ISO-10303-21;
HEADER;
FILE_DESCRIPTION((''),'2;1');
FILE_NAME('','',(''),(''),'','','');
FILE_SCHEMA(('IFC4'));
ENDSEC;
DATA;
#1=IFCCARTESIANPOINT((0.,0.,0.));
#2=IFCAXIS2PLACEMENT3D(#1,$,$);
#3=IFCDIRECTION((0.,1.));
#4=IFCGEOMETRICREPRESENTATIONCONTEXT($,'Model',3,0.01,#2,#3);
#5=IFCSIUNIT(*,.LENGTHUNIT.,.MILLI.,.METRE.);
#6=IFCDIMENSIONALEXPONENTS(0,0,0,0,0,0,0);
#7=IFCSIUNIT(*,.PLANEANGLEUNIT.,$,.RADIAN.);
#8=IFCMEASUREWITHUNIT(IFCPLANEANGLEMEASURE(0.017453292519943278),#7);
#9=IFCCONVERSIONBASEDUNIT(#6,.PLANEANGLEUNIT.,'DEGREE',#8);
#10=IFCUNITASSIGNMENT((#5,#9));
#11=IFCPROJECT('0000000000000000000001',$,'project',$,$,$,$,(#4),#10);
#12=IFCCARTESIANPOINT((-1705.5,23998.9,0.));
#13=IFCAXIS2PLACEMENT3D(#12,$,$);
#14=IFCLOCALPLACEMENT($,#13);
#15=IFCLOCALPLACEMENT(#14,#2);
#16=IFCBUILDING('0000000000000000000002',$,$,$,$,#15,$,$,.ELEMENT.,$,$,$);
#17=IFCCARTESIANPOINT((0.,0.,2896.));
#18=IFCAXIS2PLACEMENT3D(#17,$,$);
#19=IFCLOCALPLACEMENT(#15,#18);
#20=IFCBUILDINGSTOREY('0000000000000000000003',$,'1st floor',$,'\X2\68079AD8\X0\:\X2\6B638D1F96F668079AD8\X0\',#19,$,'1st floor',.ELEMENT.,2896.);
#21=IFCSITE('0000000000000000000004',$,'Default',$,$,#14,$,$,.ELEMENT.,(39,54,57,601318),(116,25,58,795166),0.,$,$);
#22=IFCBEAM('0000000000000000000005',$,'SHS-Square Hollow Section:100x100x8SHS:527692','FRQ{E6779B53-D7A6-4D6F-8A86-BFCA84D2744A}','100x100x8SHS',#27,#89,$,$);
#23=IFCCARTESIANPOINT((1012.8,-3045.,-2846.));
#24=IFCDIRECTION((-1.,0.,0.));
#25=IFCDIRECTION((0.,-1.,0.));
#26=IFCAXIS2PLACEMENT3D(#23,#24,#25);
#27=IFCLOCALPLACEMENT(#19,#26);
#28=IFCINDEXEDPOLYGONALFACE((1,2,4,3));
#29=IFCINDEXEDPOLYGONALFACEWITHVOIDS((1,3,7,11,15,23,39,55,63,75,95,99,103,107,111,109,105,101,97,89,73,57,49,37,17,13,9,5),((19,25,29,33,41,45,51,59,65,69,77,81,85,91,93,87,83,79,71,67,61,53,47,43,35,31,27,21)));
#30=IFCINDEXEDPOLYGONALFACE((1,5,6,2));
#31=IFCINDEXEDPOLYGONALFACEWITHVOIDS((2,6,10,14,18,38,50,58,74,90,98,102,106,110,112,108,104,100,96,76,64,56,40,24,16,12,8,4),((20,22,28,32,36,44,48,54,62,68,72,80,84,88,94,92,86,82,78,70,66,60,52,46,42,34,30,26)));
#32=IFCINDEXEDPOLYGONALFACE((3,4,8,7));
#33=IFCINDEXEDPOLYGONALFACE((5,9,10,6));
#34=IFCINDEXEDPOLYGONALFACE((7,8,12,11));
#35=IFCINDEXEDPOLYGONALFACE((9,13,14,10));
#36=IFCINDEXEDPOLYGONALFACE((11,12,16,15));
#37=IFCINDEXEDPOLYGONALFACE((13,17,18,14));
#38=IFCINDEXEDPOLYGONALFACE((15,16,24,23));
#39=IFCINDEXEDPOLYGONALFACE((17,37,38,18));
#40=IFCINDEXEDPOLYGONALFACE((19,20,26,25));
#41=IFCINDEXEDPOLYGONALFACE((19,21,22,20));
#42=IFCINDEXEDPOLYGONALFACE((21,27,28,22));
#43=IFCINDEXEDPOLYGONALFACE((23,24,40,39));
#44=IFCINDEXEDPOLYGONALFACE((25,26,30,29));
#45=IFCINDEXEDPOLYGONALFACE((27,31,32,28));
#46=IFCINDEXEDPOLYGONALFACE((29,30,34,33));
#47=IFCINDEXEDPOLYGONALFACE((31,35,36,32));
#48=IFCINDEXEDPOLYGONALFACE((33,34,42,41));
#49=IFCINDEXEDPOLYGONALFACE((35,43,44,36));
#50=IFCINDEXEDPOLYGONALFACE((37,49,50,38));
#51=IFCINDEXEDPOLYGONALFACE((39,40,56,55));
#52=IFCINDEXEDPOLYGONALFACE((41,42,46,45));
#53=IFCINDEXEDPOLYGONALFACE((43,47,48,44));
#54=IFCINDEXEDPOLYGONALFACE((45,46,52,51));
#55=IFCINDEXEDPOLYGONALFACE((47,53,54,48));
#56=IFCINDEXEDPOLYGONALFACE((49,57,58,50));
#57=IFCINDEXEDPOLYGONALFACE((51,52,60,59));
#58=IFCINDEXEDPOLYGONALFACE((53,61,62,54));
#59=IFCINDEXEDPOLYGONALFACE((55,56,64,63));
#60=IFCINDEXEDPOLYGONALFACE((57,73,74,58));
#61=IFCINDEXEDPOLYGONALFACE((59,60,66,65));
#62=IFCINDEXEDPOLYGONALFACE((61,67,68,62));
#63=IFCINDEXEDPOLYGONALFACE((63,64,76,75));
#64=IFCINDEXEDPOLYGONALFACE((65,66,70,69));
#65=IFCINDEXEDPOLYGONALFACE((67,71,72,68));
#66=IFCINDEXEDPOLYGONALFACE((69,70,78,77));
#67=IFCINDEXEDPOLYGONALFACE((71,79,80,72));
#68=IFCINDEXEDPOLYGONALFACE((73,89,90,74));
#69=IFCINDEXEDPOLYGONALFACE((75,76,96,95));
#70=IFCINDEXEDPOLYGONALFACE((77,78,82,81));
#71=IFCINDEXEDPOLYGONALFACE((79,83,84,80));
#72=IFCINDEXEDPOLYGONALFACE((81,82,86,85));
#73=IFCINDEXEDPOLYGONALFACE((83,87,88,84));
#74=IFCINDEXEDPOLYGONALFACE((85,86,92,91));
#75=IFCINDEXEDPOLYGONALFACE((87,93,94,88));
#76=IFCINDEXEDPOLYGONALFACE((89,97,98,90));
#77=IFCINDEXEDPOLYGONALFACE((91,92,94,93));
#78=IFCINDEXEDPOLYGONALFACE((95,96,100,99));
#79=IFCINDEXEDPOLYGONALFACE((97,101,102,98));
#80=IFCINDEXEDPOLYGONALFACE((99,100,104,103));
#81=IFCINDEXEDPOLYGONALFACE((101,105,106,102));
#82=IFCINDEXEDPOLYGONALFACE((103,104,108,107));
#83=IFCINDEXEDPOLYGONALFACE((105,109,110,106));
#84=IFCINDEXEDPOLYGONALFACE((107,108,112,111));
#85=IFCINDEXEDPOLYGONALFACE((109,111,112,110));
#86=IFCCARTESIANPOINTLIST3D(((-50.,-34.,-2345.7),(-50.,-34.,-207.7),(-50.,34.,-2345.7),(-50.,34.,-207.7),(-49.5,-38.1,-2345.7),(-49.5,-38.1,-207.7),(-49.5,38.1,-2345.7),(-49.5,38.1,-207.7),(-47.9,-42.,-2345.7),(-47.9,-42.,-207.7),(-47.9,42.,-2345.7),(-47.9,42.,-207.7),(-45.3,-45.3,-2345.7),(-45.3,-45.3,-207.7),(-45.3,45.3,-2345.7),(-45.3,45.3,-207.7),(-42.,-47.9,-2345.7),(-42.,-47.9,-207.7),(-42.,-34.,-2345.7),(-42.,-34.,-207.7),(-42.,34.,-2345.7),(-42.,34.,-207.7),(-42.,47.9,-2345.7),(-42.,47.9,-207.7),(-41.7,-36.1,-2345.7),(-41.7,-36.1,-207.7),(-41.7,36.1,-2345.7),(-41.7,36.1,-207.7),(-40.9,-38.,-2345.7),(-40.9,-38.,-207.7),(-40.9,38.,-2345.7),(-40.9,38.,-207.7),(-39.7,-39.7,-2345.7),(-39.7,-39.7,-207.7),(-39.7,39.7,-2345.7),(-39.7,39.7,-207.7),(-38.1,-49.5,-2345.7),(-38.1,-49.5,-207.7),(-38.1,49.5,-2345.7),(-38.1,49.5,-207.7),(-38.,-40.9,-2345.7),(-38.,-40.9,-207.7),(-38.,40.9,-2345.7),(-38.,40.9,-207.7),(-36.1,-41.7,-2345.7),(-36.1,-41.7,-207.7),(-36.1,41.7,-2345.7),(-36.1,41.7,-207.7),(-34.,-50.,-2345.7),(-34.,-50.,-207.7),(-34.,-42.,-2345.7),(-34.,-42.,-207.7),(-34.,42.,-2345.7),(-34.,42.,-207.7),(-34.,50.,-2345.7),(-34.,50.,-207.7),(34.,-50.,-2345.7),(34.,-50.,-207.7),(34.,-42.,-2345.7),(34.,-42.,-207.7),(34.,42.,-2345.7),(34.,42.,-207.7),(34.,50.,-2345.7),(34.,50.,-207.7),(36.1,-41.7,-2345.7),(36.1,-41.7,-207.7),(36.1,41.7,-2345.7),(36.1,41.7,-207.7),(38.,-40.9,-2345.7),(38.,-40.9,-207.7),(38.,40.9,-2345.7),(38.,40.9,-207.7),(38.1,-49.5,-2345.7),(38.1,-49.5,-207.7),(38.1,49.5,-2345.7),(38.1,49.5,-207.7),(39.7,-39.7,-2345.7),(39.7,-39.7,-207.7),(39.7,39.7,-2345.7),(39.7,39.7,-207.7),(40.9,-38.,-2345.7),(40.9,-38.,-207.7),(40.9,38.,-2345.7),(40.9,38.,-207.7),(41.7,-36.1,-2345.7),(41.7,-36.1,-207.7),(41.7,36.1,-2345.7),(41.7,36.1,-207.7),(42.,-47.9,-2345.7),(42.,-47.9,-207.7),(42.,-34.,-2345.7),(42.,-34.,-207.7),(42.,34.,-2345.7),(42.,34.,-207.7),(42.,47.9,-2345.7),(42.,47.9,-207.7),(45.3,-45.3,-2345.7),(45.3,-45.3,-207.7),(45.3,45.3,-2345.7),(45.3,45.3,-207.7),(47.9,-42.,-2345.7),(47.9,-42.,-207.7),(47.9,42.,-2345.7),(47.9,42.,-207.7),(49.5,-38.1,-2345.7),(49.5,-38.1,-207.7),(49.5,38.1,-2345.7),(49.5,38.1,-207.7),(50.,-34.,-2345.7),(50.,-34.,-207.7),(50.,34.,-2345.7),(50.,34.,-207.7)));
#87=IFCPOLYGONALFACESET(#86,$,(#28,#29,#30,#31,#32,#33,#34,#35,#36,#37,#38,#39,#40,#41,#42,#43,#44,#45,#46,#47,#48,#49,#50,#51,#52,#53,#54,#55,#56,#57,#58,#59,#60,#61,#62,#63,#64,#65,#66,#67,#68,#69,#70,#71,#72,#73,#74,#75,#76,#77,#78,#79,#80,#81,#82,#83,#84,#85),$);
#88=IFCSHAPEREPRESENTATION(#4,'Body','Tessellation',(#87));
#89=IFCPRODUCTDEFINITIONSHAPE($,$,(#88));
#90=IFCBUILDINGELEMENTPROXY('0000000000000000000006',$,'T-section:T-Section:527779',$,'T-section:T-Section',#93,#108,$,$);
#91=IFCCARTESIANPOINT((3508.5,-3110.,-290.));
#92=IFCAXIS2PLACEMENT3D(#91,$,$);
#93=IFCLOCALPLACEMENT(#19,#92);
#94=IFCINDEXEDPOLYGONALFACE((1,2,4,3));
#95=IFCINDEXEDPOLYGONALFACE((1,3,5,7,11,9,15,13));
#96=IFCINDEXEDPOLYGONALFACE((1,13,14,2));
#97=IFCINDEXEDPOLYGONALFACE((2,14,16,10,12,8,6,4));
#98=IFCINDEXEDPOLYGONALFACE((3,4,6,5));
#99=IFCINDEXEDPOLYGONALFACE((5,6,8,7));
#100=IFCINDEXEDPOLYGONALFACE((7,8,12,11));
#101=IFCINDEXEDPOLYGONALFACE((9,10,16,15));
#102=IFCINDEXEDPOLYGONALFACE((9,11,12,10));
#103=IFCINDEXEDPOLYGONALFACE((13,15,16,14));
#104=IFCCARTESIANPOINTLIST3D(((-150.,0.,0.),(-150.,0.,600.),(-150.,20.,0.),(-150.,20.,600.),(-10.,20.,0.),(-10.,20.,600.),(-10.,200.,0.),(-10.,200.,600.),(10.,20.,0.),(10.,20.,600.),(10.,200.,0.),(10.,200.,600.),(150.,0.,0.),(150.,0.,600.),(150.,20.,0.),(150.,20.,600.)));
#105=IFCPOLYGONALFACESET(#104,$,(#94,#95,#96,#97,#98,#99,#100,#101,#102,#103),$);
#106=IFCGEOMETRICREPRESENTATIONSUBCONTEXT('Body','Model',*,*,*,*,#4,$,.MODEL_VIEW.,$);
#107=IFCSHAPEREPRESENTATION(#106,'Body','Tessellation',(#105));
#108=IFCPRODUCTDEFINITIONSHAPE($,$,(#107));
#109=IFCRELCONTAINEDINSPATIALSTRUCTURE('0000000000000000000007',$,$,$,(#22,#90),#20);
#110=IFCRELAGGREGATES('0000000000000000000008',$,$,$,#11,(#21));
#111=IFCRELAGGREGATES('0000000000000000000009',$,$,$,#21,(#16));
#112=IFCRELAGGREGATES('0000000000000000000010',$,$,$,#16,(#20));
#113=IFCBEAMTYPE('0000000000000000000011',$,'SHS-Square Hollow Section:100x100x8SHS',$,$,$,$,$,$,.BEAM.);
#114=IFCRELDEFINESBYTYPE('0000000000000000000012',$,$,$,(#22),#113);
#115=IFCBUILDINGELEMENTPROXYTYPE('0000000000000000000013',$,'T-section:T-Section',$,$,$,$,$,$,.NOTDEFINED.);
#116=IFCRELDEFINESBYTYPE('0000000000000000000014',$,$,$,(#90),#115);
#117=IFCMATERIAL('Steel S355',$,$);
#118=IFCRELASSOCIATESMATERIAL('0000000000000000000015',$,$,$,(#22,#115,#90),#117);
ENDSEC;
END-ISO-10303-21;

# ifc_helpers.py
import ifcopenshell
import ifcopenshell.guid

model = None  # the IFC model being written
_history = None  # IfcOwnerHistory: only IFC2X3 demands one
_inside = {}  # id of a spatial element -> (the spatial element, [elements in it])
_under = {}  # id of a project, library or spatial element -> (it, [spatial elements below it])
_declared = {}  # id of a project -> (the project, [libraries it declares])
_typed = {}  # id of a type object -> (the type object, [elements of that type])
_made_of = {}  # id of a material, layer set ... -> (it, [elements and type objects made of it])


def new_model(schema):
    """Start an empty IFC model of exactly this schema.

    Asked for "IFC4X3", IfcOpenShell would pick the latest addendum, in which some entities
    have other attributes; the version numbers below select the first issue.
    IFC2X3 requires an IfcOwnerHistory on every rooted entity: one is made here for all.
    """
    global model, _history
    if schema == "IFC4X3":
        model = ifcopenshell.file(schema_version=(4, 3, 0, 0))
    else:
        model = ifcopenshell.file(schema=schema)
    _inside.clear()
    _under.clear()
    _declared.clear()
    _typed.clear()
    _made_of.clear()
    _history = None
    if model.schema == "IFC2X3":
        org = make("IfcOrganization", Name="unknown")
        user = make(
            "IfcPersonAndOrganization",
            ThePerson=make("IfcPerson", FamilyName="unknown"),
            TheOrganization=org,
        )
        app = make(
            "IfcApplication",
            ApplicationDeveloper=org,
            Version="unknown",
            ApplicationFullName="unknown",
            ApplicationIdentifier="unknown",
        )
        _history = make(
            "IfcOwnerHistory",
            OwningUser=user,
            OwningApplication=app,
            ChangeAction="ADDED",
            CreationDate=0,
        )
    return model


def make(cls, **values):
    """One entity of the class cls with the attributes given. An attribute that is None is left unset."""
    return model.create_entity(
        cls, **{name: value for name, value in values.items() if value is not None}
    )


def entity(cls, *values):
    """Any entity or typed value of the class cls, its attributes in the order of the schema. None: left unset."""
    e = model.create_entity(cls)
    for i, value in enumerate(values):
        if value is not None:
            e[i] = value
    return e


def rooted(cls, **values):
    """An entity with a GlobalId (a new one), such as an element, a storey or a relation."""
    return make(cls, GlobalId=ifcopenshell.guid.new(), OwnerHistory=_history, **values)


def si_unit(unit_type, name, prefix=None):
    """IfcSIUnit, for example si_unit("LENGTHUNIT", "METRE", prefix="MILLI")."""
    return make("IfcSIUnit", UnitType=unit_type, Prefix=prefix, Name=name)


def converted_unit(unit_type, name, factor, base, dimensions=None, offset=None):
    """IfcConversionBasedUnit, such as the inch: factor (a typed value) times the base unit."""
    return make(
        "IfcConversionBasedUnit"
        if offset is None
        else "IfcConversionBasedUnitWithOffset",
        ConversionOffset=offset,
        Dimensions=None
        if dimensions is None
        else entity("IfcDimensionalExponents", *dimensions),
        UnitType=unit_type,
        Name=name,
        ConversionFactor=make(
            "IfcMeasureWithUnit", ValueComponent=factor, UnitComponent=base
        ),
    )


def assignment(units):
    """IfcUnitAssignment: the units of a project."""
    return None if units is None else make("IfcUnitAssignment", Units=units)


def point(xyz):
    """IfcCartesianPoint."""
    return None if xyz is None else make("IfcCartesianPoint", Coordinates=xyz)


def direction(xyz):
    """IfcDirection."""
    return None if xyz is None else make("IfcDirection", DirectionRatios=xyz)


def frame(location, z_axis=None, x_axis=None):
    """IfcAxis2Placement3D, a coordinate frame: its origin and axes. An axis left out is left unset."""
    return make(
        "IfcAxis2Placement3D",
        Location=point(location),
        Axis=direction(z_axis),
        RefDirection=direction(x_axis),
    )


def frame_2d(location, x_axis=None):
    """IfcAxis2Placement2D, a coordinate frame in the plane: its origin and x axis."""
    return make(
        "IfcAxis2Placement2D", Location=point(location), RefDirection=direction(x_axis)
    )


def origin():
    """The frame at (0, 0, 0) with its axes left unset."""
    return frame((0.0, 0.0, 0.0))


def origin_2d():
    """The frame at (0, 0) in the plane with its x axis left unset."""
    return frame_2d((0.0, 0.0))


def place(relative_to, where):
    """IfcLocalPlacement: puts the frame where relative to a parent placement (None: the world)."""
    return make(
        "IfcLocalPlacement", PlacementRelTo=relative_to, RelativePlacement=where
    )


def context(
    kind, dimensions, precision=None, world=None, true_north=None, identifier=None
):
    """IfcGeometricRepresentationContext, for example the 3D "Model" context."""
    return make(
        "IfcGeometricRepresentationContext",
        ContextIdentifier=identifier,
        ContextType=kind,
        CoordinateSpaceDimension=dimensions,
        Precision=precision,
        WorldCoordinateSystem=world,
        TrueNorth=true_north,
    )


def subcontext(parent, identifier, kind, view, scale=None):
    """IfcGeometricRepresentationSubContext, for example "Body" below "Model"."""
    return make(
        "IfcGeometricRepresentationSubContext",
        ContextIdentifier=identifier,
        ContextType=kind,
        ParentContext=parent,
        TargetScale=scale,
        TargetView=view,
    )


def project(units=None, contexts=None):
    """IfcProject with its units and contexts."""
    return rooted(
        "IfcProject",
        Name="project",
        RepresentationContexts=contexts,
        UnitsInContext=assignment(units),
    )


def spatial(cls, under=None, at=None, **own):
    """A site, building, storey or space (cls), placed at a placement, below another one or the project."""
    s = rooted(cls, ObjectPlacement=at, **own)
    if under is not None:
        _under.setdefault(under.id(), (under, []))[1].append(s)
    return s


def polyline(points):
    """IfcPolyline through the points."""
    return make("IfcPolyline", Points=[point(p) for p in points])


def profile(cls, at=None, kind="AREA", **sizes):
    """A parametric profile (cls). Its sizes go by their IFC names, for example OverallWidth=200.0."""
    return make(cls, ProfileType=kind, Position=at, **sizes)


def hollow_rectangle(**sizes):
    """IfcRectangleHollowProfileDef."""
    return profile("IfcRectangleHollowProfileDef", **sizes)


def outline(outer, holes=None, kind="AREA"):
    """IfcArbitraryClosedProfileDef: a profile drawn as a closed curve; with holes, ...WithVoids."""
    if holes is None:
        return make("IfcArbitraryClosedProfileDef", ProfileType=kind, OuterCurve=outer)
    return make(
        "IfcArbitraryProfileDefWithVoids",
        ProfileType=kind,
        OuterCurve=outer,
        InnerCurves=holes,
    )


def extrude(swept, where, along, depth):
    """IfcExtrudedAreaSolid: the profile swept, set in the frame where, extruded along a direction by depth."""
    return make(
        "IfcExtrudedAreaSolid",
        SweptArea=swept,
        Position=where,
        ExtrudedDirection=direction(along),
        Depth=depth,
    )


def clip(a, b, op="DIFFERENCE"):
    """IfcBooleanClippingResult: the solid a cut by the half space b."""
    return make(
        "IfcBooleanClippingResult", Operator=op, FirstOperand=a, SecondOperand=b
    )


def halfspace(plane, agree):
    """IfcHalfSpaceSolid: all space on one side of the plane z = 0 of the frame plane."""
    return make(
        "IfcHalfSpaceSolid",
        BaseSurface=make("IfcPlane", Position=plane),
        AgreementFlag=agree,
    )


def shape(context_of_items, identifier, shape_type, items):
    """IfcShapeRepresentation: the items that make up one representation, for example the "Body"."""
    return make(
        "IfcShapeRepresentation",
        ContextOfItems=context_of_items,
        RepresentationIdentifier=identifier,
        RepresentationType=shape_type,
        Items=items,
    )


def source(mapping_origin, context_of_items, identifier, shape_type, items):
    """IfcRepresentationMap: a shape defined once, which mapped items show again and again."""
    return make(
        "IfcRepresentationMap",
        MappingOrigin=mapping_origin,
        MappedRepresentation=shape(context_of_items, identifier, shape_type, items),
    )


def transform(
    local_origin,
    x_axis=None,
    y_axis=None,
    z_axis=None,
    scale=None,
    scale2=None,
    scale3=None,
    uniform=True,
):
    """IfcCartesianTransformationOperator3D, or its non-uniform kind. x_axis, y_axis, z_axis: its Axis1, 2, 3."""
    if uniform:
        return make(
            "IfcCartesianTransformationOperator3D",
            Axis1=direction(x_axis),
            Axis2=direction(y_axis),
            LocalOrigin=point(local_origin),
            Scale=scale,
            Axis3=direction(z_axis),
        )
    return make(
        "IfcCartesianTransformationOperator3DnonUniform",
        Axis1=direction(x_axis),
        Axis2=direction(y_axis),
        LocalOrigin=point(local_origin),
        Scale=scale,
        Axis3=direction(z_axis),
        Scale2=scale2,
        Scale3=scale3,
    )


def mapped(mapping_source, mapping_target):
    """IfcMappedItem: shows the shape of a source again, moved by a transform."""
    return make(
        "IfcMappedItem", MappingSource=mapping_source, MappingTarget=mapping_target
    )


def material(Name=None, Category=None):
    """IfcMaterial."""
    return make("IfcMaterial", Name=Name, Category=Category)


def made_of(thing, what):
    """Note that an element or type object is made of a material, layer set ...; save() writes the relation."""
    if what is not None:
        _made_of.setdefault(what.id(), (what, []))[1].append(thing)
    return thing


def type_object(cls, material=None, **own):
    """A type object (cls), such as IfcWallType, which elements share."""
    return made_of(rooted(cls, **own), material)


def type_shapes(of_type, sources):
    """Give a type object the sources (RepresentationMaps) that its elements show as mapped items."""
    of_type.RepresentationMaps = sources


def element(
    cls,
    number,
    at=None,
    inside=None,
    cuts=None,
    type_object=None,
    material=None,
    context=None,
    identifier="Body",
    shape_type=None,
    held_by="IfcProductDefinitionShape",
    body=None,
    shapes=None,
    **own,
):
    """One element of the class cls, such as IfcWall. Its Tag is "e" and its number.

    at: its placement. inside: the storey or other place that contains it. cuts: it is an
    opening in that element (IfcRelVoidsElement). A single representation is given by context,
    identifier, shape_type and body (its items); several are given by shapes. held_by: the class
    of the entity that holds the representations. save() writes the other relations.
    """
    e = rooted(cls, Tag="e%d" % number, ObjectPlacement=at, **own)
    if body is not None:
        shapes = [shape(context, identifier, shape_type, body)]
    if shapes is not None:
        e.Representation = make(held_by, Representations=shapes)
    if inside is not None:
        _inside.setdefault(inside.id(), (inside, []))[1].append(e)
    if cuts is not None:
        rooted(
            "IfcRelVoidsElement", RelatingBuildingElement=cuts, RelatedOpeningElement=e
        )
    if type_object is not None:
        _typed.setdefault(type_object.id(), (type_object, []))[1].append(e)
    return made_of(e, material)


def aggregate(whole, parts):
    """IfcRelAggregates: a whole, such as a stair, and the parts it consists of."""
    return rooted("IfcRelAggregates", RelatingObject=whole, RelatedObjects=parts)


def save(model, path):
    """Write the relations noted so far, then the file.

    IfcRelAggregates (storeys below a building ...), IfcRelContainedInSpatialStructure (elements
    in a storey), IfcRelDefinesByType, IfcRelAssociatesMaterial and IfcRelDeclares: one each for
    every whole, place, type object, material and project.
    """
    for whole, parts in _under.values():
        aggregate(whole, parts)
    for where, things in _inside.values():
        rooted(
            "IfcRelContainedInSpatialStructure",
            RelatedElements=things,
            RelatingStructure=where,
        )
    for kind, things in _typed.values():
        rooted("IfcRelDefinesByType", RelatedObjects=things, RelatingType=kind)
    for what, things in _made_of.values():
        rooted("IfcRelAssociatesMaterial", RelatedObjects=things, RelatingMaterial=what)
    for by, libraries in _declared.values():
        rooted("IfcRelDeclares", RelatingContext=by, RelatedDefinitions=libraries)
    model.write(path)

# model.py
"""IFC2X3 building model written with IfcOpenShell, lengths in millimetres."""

from ifc_helpers import new_model, entity, si_unit, converted_unit, direction, frame, origin, origin_2d, place, context, subcontext, project, spatial, polyline, hollow_rectangle, outline, extrude, clip, halfspace, source, transform, mapped, material, type_object, type_shapes, element, save


model = new_model("IFC2X3")

# Units and contexts
model_context = context("Model", 3, precision=0.01, world=origin(), true_north=direction((0.0, 1.0)))
body_context = subcontext(model_context, "Body", "Model", "MODEL_VIEW")
ifc_project = project(units=[si_unit("LENGTHUNIT", "METRE", prefix="MILLI"), converted_unit("PLANEANGLEUNIT", "DEGREE", entity("IfcPlaneAngleMeasure", 0.017453292519943278), si_unit("PLANEANGLEUNIT", "RADIAN"), dimensions=[0, 0, 0, 0, 0, 0, 0])], contexts=[model_context])

# Site, building, storey
site_placement = place(None, frame((-1705.5, 23998.9, 0.0)))
site = spatial("IfcSite", under=ifc_project, at=site_placement, Name="Default", CompositionType="ELEMENT", RefLatitude=(39, 54, 57, 601318), RefLongitude=(116, 25, 58, 795166), RefElevation=0.0)
building_placement = place(site_placement, origin())
building = spatial("IfcBuilding", under=site, at=building_placement, CompositionType="ELEMENT")
storey_placement = place(building_placement, frame((0.0, 0.0, 2896.0)))
storey = spatial("IfcBuildingStorey", under=building, at=storey_placement, Name="1st floor", ObjectType="标高:正负零标高", LongName="1st floor", CompositionType="ELEMENT", Elevation=2896.0)

# Shared definitions
ifc_material_1 = material(Name="Steel S355")

# Beam
beam_type_1 = type_object("IfcBeamType", Name="SHS-Square Hollow Section:100x100x8SHS", PredefinedType="BEAM")
beam_1_placement = place(storey_placement, frame((1012.8, -3045.0, -2846.0), z_axis=(-1.0, 0.0, 0.0), x_axis=(0.0, -1.0, 0.0)))
element("IfcBeam", 1, at=beam_1_placement, inside=storey, type_object=beam_type_1, material=ifc_material_1, Name="SHS-Square Hollow Section:100x100x8SHS:527692", Description="FRQ{E6779B53-D7A6-4D6F-8A86-BFCA84D2744A}", ObjectType="100x100x8SHS", context=model_context, shape_type="Clipping", body=[
    clip(clip(extrude(hollow_rectangle(XDim=100.0, YDim=100.0, WallThickness=8.0, InnerFilletRadius=8.0, OuterFilletRadius=16.0, at=origin_2d()), origin(), (0.0, 0.0, -1.0), 2551.4), halfspace(frame((-3045.0, -50.0, -2345.7), z_axis=(0.0, 0.0, 1.0), x_axis=(1.0, 0.0, 0.0)), True)), halfspace(frame((-3045.0, -50.0, -207.7), z_axis=(0.0, 0.0, -1.0), x_axis=(-1.0, 0.0, 0.0)), True)),
])

# Building element proxy
building_element_proxy_type_1 = type_object("IfcBuildingElementProxyType", Name="T-section:T-Section", PredefinedType="NOTDEFINED", material=ifc_material_1)
shared_shape_1 = source(origin(), body_context, "Body", "SweptSolid", [
    extrude(outline(polyline([(-140.0, 10.0), (-140.0, -10.0), (40.0, -10.0), (40.0, -150.0), (60.0, -150.0), (60.0, 150.0), (40.0, 150.0), (40.0, 10.0), (-140.0, 10.0)])), frame((0.0, 60.0, 0.0), z_axis=(0.0, 0.0, -1.0), x_axis=(0.0, -1.0, 0.0)), (0.0, 0.0, -1.0), 600.0),
])
type_shapes(building_element_proxy_type_1, [shared_shape_1])
proxy_1_placement = place(storey_placement, frame((3508.5, -3110.0, -290.0)))
element("IfcBuildingElementProxy", 2, at=proxy_1_placement, inside=storey, type_object=building_element_proxy_type_1, material=ifc_material_1, Name="T-section:T-Section:527779", ObjectType="T-section:T-Section", context=body_context, shape_type="MappedRepresentation", body=[
    mapped(shared_shape_1, transform((0.0, 0.0, 0.0), scale=1.0)),
])

save(model, "model.ifc")
